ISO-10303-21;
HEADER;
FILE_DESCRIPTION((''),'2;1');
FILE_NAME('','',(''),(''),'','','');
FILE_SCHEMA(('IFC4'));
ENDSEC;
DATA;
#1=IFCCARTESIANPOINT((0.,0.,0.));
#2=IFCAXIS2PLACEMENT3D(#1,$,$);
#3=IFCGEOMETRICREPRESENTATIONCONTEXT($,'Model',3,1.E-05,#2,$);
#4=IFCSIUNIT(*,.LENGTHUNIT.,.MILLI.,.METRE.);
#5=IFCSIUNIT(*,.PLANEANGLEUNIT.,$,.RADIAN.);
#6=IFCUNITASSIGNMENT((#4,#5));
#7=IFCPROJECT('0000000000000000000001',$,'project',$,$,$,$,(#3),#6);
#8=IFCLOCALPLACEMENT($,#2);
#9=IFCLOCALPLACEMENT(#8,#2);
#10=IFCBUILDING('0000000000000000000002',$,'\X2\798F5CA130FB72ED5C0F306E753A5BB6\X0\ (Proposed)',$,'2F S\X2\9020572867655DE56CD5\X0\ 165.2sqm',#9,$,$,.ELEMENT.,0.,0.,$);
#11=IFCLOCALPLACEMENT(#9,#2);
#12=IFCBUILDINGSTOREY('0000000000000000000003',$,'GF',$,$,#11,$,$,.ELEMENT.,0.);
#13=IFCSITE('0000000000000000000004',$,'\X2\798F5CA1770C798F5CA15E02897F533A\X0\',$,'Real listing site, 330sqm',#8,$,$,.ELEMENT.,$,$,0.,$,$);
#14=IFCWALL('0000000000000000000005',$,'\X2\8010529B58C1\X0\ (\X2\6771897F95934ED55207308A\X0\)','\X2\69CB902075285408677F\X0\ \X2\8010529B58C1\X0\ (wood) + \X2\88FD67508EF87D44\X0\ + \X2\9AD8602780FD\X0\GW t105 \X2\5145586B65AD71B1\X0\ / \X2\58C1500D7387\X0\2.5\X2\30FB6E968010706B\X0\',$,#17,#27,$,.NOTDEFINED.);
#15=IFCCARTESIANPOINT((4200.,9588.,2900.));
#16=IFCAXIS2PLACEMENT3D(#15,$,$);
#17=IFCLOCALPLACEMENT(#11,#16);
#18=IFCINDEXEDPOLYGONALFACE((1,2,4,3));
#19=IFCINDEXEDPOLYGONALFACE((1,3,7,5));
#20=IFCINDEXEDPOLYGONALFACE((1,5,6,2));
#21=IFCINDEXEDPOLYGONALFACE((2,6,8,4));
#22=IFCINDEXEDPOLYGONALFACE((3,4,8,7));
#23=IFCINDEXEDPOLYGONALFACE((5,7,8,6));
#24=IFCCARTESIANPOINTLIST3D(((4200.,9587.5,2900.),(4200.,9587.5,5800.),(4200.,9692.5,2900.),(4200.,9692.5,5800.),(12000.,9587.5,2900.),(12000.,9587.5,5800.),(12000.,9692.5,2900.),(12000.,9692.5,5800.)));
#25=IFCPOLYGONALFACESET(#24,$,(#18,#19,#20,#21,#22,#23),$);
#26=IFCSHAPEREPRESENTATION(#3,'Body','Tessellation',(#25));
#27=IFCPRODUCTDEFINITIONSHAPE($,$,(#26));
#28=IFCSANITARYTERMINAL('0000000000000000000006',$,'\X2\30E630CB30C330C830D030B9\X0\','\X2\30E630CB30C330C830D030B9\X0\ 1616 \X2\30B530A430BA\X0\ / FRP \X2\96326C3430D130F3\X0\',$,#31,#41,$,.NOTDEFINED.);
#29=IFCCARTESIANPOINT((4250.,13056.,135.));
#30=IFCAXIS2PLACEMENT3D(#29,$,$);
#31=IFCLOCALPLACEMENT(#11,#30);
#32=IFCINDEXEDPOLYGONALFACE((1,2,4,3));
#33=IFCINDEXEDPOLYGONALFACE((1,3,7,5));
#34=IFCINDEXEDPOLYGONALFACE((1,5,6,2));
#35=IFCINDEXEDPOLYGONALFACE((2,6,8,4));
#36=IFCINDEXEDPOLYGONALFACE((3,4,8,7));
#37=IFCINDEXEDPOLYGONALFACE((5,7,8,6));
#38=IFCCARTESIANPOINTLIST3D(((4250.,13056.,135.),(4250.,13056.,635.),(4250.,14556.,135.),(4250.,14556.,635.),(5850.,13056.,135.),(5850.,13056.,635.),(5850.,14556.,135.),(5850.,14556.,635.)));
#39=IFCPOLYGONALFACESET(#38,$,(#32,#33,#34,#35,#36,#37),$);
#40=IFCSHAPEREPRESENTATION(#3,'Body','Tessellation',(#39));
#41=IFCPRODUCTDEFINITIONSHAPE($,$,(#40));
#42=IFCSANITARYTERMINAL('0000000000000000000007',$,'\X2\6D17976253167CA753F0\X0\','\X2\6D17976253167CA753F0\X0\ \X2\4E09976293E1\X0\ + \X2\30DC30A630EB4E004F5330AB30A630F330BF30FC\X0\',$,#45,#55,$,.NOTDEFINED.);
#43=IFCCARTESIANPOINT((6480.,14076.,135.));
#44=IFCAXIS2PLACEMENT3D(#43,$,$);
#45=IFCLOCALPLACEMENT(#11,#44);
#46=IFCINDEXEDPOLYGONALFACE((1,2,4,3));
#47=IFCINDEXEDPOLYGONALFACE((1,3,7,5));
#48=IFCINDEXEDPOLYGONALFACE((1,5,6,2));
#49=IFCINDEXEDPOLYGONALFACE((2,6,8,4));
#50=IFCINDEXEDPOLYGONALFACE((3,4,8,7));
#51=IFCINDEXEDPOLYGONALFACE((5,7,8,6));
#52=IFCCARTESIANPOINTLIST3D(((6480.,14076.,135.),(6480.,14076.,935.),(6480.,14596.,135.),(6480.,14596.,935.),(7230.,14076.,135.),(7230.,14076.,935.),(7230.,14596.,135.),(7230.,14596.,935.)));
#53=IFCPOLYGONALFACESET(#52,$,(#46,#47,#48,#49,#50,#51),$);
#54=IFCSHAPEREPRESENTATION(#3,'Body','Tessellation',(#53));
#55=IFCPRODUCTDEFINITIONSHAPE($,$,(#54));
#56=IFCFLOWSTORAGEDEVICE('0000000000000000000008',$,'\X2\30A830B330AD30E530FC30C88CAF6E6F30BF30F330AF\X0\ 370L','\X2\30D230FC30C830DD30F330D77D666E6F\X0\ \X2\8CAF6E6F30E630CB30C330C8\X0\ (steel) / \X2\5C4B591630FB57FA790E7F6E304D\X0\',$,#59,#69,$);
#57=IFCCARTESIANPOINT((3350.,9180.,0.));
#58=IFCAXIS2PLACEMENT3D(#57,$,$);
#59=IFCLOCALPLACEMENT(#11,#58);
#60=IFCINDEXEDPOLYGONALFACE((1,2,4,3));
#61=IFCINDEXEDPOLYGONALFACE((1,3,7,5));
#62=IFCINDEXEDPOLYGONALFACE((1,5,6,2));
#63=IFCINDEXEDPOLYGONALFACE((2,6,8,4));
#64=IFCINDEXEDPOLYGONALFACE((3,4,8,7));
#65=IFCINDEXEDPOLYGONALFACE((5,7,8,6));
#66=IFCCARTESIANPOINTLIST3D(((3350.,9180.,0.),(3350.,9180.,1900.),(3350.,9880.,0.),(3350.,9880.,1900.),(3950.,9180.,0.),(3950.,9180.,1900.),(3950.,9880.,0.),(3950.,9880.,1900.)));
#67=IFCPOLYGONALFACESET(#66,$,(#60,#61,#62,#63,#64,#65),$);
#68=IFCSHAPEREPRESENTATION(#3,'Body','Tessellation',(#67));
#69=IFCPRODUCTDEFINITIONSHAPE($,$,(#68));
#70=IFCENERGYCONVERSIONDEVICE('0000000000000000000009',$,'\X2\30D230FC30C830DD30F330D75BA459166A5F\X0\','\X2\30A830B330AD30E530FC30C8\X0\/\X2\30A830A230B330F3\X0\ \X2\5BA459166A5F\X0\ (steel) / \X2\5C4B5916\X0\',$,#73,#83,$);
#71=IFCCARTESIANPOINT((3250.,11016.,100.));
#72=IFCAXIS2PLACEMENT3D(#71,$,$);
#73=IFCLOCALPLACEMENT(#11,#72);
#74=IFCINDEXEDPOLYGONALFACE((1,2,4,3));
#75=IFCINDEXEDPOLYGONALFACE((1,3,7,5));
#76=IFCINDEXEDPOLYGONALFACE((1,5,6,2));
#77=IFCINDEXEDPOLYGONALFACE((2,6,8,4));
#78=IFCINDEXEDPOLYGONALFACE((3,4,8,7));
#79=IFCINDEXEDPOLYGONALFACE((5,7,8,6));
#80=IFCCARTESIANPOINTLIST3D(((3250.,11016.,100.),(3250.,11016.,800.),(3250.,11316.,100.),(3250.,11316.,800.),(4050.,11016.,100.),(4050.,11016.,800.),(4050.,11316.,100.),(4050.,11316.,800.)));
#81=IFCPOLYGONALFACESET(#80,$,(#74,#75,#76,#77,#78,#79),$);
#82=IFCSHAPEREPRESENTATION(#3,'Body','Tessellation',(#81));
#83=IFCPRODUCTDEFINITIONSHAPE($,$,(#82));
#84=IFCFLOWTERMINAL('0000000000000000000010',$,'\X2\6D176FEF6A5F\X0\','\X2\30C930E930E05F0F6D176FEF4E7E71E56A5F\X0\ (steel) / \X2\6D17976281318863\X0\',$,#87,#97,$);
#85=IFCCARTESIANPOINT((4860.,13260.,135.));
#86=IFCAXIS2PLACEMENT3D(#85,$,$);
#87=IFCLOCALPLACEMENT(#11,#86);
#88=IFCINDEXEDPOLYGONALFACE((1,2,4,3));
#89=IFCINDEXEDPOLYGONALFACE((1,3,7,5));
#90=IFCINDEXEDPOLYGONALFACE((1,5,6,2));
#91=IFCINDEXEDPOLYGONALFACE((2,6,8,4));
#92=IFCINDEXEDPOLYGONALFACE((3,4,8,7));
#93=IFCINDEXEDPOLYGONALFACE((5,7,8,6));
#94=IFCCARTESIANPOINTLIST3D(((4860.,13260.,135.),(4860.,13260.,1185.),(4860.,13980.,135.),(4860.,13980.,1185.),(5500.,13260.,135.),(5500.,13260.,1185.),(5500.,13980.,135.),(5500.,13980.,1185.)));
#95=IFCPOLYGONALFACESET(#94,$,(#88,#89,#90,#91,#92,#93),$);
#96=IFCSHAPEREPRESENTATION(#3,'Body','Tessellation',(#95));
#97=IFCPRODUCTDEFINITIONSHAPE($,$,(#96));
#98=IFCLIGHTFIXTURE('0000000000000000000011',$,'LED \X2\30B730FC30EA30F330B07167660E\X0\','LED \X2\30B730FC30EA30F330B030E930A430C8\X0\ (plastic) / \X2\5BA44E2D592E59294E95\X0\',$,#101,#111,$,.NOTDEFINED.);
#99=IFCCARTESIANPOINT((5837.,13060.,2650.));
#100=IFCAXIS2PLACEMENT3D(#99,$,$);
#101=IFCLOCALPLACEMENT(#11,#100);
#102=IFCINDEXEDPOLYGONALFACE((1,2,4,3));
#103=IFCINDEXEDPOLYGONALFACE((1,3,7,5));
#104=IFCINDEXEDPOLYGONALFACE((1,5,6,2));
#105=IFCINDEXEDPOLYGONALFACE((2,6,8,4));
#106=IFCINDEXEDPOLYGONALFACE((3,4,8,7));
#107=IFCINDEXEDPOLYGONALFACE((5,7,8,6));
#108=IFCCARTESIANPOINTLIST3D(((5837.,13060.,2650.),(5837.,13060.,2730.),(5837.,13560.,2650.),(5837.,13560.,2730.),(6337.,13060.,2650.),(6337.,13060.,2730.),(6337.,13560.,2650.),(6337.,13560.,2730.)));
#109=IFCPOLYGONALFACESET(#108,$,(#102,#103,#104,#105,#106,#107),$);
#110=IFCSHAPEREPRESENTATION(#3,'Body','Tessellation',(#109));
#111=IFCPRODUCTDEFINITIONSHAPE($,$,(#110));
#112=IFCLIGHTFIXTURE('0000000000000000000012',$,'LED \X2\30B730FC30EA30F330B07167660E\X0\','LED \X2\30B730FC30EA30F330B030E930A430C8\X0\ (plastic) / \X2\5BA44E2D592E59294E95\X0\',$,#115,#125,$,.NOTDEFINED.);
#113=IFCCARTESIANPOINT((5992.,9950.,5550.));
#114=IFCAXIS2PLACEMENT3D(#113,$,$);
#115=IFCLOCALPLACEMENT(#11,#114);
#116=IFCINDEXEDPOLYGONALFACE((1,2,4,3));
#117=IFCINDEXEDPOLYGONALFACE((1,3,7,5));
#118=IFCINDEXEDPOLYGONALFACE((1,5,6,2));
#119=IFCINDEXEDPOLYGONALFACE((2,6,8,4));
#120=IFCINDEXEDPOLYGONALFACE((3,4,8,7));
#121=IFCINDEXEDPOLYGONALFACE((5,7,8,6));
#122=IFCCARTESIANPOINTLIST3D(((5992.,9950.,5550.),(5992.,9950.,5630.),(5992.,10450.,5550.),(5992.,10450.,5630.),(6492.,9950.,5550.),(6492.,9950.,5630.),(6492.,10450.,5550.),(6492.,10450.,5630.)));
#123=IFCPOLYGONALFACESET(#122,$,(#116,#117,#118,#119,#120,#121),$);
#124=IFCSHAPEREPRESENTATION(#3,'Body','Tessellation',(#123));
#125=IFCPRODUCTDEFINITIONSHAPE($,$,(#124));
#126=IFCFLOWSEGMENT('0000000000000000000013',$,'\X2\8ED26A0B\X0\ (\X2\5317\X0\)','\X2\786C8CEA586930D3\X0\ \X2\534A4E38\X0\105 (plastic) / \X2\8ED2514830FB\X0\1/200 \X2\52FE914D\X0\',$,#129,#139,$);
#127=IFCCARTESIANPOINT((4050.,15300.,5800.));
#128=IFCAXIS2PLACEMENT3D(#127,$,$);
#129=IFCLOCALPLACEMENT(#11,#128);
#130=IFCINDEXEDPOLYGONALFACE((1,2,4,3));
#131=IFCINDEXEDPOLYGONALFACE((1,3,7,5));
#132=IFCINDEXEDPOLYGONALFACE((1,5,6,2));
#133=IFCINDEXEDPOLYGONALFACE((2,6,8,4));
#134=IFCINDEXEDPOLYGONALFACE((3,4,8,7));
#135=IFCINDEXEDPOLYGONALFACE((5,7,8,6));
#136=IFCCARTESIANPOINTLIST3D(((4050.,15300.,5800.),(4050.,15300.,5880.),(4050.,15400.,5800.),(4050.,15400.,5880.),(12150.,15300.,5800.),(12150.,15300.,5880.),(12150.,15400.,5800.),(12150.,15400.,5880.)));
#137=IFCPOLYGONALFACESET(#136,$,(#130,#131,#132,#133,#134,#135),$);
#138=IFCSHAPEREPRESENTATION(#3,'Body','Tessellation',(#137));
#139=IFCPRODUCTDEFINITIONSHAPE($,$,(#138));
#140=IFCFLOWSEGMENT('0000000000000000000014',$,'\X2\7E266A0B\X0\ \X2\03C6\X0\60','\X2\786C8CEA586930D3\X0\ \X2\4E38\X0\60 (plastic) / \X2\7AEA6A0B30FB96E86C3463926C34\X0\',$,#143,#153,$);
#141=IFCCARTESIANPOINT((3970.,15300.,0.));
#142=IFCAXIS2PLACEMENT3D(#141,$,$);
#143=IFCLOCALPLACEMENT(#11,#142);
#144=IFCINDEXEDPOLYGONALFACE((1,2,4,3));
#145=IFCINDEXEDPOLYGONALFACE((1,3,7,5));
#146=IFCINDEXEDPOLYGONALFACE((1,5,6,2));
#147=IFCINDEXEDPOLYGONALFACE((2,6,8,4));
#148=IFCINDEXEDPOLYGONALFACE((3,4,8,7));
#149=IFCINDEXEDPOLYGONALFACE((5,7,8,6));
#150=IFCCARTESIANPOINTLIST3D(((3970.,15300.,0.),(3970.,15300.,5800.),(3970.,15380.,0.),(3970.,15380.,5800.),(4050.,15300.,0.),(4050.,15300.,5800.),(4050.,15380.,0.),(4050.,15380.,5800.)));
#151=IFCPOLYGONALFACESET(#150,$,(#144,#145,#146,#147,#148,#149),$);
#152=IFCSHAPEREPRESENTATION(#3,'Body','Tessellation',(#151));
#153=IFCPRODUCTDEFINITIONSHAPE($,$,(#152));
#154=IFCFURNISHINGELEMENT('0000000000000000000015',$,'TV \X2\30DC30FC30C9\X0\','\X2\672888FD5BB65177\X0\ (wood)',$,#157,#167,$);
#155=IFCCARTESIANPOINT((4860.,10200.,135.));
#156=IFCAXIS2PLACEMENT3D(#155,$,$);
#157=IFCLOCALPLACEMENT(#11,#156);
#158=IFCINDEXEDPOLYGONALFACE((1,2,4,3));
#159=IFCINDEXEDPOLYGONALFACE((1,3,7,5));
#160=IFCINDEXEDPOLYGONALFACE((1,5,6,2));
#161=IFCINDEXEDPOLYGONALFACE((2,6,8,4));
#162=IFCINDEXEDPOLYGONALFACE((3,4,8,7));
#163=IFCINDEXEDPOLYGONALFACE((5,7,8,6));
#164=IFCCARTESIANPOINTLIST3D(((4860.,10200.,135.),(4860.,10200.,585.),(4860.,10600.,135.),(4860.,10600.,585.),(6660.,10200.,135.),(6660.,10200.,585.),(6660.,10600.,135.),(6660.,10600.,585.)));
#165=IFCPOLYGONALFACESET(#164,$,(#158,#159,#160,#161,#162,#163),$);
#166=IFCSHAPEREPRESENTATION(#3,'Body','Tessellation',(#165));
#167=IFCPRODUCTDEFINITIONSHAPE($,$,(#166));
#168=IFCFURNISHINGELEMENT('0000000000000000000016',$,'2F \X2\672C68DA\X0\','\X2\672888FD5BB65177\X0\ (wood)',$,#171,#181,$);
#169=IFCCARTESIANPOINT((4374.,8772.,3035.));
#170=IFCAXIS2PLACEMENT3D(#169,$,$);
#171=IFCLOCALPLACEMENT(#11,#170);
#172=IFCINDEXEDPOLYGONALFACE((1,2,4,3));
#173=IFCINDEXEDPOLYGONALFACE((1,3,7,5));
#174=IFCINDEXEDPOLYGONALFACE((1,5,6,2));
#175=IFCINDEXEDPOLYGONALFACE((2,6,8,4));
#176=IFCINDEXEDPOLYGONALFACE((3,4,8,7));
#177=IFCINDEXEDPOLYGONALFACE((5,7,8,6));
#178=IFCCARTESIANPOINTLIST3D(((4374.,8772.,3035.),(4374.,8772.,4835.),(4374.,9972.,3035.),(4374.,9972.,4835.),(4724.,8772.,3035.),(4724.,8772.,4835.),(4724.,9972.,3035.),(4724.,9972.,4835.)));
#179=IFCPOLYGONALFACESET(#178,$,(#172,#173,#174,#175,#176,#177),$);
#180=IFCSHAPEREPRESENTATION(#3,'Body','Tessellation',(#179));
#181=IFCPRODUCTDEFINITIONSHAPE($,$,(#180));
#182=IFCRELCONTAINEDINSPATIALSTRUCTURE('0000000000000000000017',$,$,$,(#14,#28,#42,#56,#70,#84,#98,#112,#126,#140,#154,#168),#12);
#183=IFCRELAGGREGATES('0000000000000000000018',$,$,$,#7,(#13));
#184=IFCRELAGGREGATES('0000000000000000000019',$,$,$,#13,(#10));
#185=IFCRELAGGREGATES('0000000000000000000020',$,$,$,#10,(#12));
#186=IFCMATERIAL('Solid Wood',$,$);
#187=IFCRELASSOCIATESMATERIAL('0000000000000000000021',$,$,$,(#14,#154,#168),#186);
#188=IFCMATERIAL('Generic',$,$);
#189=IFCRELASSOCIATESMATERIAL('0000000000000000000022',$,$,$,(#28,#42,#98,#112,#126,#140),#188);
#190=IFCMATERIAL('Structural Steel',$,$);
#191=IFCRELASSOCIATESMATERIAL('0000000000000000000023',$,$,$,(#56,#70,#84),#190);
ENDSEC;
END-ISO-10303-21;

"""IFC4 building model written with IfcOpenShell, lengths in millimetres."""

from ifc_helpers import new_model, si_unit, frame, frame_2d, origin, place, context, project, spatial, rectangle, extrude, material, element, save


model = new_model("IFC4")

# Units and contexts
model_context = context("Model", 3, precision=1e-05, world=origin())
ifc_project = project(units=[si_unit("LENGTHUNIT", "METRE", prefix="MILLI"), si_unit("PLANEANGLEUNIT", "RADIAN")], contexts=[model_context])

# Site, building, storey
site_placement = place(None, origin())
site = spatial("IfcSite", under=ifc_project, at=site_placement, Name="福岡県福岡市西区", ObjectType="Real listing site, 330sqm", CompositionType="ELEMENT", RefElevation=0.0)
building_placement = place(site_placement, origin())
building = spatial("IfcBuilding", under=site, at=building_placement, Name="福岡・狭小の町家 (Proposed)", ObjectType="2F S造在来工法 165.2sqm", CompositionType="ELEMENT", ElevationOfRefHeight=0.0, ElevationOfTerrain=0.0)
storey_placement = place(building_placement, origin())
storey = spatial("IfcBuildingStorey", under=building, at=storey_placement, Name="GF", CompositionType="ELEMENT", Elevation=0.0)

# Shared definitions
ifc_material_1 = material(Name="Solid Wood")

# Wall
wall_1_placement = place(storey_placement, frame((4200.0, 9588.0, 2900.0)))
element("IfcWall", 1, at=wall_1_placement, inside=storey, material=ifc_material_1, Name="耐力壁 (東西間仕切り)", Description="構造用合板 耐力壁 (wood) + 製材軸組 + 高性能GW t105 充填断熱 / 壁倍率2.5・準耐火", PredefinedType="NOTDEFINED", context=model_context, shape_type="SweptSolid", body=[
    extrude(rectangle(XDim=7800.0, YDim=105.0, at=frame_2d((3900.0, 52.0))), frame((4200.0, 9588.0, 2900.0)), (0.0, 0.0, 1.0), 2900.0),
])

# Sanitary terminals
ifc_material_2 = material(Name="Generic")
sanitary_terminal_1_placement = place(storey_placement, frame((4250.0, 13056.0, 135.0)))
element("IfcSanitaryTerminal", 2, at=sanitary_terminal_1_placement, inside=storey, material=ifc_material_2, Name="ユニットバス", Description="ユニットバス 1616 サイズ / FRP 防水パン", PredefinedType="NOTDEFINED", context=model_context, shape_type="SweptSolid", body=[
    extrude(rectangle(XDim=1600.0, YDim=1500.0, at=frame_2d((800.0, 750.0))), frame((4250.0, 13056.0, 135.0)), (0.0, 0.0, 1.0), 500.0),
])
sanitary_terminal_2_placement = place(storey_placement, frame((6480.0, 14076.0, 135.0)))
element("IfcSanitaryTerminal", 3, at=sanitary_terminal_2_placement, inside=storey, material=ifc_material_2, Name="洗面化粧台", Description="洗面化粧台 三面鏡 + ボウル一体カウンター", PredefinedType="NOTDEFINED", context=model_context, shape_type="SweptSolid", body=[
    extrude(rectangle(XDim=750.0, YDim=520.0, at=frame_2d((375.0, 260.0))), frame((6480.0, 14076.0, 135.0)), (0.0, 0.0, 1.0), 800.0),
])

# Flow storage device
ifc_material_3 = material(Name="Structural Steel")
flow_storage_device_placement = place(storey_placement, frame((3350.0, 9180.0, 0.0)))
element("IfcFlowStorageDevice", 4, at=flow_storage_device_placement, inside=storey, material=ifc_material_3, Name="エコキュート貯湯タンク 370L", Description="ヒートポンプ給湯 貯湯ユニット (steel) / 屋外・基礎置き", context=model_context, shape_type="SweptSolid", body=[
    extrude(rectangle(XDim=600.0, YDim=700.0, at=frame_2d((300.0, 350.0))), frame((3350.0, 9180.0, 0.0)), (0.0, 0.0, 1.0), 1900.0),
])

# Energy conversion device
energy_conversion_device_placement = place(storey_placement, frame((3250.0, 11016.0, 100.0)))
element("IfcEnergyConversionDevice", 5, at=energy_conversion_device_placement, inside=storey, material=ifc_material_3, Name="ヒートポンプ室外機", Description="エコキュート/エアコン 室外機 (steel) / 屋外", context=model_context, shape_type="SweptSolid", body=[
    extrude(rectangle(XDim=800.0, YDim=300.0, at=frame_2d((400.0, 150.0))), frame((3250.0, 11016.0, 100.0)), (0.0, 0.0, 1.0), 700.0),
])

# Flow terminal
flow_terminal_placement = place(storey_placement, frame((4860.0, 13260.0, 135.0)))
element("IfcFlowTerminal", 6, at=flow_terminal_placement, inside=storey, material=ifc_material_3, Name="洗濯機", Description="ドラム式洗濯乾燥機 (steel) / 洗面脱衣", context=model_context, shape_type="SweptSolid", body=[
    extrude(rectangle(XDim=640.0, YDim=720.0, at=frame_2d((320.0, 360.0))), frame((4860.0, 13260.0, 135.0)), (0.0, 0.0, 1.0), 1050.0),
])

# Light fixtures
light_fixture_1_placement = place(storey_placement, frame((5837.0, 13060.0, 2650.0)))
element("IfcLightFixture", 7, at=light_fixture_1_placement, inside=storey, material=ifc_material_2, Name="LED シーリング照明", Description="LED シーリングライト (plastic) / 室中央天井", PredefinedType="NOTDEFINED", context=model_context, shape_type="SweptSolid", body=[
    extrude(rectangle(XDim=500.0, YDim=500.0, at=frame_2d((250.0, 250.0))), frame((5837.0, 13060.0, 2650.0)), (0.0, 0.0, 1.0), 80.0),
])
light_fixture_2_placement = place(storey_placement, frame((5992.0, 9950.0, 5550.0)))
element("IfcLightFixture", 8, at=light_fixture_2_placement, inside=storey, material=ifc_material_2, Name="LED シーリング照明", Description="LED シーリングライト (plastic) / 室中央天井", PredefinedType="NOTDEFINED", context=model_context, shape_type="SweptSolid", body=[
    extrude(rectangle(XDim=500.0, YDim=500.0, at=frame_2d((250.0, 250.0))), frame((5992.0, 9950.0, 5550.0)), (0.0, 0.0, 1.0), 80.0),
])

# Flow segments
flow_segment_1_placement = place(storey_placement, frame((4050.0, 15300.0, 5800.0)))
element("IfcFlowSegment", 9, at=flow_segment_1_placement, inside=storey, material=ifc_material_2, Name="軒樋 (北)", Description="硬質塩ビ 半丸105 (plastic) / 軒先・1/200 勾配", context=model_context, shape_type="SweptSolid", body=[
    extrude(rectangle(XDim=8100.0, YDim=100.0, at=frame_2d((4050.0, 50.0))), frame((4050.0, 15300.0, 5800.0)), (0.0, 0.0, 1.0), 80.0),
])
flow_segment_2_placement = place(storey_placement, frame((3970.0, 15300.0, 0.0)))
element("IfcFlowSegment", 10, at=flow_segment_2_placement, inside=storey, material=ifc_material_2, Name="縦樋 φ60", Description="硬質塩ビ 丸60 (plastic) / 竪樋・雨水排水", context=model_context, shape_type="SweptSolid", body=[
    extrude(rectangle(XDim=80.0, YDim=80.0, at=frame_2d((40.0, 40.0))), frame((3970.0, 15300.0, 0.0)), (0.0, 0.0, 1.0), 5800.0),
])

# Furnishing elements
furnishing_1_placement = place(storey_placement, frame((4860.0, 10200.0, 135.0)))
element("IfcFurnishingElement", 11, at=furnishing_1_placement, inside=storey, material=ifc_material_1, Name="TV ボード", Description="木製家具 (wood)", context=model_context, shape_type="SweptSolid", body=[
    extrude(rectangle(XDim=1800.0, YDim=400.0, at=frame_2d((900.0, 200.0))), frame((4860.0, 10200.0, 135.0)), (0.0, 0.0, 1.0), 450.0),
])
furnishing_2_placement = place(storey_placement, frame((4374.0, 8772.0, 3035.0)))
element("IfcFurnishingElement", 12, at=furnishing_2_placement, inside=storey, material=ifc_material_1, Name="2F 本棚", Description="木製家具 (wood)", context=model_context, shape_type="SweptSolid", body=[
    extrude(rectangle(XDim=350.0, YDim=1200.0, at=frame_2d((175.0, 600.0))), frame((4374.0, 8772.0, 3035.0)), (0.0, 0.0, 1.0), 1800.0),
])

save(model, "model.ifc")
